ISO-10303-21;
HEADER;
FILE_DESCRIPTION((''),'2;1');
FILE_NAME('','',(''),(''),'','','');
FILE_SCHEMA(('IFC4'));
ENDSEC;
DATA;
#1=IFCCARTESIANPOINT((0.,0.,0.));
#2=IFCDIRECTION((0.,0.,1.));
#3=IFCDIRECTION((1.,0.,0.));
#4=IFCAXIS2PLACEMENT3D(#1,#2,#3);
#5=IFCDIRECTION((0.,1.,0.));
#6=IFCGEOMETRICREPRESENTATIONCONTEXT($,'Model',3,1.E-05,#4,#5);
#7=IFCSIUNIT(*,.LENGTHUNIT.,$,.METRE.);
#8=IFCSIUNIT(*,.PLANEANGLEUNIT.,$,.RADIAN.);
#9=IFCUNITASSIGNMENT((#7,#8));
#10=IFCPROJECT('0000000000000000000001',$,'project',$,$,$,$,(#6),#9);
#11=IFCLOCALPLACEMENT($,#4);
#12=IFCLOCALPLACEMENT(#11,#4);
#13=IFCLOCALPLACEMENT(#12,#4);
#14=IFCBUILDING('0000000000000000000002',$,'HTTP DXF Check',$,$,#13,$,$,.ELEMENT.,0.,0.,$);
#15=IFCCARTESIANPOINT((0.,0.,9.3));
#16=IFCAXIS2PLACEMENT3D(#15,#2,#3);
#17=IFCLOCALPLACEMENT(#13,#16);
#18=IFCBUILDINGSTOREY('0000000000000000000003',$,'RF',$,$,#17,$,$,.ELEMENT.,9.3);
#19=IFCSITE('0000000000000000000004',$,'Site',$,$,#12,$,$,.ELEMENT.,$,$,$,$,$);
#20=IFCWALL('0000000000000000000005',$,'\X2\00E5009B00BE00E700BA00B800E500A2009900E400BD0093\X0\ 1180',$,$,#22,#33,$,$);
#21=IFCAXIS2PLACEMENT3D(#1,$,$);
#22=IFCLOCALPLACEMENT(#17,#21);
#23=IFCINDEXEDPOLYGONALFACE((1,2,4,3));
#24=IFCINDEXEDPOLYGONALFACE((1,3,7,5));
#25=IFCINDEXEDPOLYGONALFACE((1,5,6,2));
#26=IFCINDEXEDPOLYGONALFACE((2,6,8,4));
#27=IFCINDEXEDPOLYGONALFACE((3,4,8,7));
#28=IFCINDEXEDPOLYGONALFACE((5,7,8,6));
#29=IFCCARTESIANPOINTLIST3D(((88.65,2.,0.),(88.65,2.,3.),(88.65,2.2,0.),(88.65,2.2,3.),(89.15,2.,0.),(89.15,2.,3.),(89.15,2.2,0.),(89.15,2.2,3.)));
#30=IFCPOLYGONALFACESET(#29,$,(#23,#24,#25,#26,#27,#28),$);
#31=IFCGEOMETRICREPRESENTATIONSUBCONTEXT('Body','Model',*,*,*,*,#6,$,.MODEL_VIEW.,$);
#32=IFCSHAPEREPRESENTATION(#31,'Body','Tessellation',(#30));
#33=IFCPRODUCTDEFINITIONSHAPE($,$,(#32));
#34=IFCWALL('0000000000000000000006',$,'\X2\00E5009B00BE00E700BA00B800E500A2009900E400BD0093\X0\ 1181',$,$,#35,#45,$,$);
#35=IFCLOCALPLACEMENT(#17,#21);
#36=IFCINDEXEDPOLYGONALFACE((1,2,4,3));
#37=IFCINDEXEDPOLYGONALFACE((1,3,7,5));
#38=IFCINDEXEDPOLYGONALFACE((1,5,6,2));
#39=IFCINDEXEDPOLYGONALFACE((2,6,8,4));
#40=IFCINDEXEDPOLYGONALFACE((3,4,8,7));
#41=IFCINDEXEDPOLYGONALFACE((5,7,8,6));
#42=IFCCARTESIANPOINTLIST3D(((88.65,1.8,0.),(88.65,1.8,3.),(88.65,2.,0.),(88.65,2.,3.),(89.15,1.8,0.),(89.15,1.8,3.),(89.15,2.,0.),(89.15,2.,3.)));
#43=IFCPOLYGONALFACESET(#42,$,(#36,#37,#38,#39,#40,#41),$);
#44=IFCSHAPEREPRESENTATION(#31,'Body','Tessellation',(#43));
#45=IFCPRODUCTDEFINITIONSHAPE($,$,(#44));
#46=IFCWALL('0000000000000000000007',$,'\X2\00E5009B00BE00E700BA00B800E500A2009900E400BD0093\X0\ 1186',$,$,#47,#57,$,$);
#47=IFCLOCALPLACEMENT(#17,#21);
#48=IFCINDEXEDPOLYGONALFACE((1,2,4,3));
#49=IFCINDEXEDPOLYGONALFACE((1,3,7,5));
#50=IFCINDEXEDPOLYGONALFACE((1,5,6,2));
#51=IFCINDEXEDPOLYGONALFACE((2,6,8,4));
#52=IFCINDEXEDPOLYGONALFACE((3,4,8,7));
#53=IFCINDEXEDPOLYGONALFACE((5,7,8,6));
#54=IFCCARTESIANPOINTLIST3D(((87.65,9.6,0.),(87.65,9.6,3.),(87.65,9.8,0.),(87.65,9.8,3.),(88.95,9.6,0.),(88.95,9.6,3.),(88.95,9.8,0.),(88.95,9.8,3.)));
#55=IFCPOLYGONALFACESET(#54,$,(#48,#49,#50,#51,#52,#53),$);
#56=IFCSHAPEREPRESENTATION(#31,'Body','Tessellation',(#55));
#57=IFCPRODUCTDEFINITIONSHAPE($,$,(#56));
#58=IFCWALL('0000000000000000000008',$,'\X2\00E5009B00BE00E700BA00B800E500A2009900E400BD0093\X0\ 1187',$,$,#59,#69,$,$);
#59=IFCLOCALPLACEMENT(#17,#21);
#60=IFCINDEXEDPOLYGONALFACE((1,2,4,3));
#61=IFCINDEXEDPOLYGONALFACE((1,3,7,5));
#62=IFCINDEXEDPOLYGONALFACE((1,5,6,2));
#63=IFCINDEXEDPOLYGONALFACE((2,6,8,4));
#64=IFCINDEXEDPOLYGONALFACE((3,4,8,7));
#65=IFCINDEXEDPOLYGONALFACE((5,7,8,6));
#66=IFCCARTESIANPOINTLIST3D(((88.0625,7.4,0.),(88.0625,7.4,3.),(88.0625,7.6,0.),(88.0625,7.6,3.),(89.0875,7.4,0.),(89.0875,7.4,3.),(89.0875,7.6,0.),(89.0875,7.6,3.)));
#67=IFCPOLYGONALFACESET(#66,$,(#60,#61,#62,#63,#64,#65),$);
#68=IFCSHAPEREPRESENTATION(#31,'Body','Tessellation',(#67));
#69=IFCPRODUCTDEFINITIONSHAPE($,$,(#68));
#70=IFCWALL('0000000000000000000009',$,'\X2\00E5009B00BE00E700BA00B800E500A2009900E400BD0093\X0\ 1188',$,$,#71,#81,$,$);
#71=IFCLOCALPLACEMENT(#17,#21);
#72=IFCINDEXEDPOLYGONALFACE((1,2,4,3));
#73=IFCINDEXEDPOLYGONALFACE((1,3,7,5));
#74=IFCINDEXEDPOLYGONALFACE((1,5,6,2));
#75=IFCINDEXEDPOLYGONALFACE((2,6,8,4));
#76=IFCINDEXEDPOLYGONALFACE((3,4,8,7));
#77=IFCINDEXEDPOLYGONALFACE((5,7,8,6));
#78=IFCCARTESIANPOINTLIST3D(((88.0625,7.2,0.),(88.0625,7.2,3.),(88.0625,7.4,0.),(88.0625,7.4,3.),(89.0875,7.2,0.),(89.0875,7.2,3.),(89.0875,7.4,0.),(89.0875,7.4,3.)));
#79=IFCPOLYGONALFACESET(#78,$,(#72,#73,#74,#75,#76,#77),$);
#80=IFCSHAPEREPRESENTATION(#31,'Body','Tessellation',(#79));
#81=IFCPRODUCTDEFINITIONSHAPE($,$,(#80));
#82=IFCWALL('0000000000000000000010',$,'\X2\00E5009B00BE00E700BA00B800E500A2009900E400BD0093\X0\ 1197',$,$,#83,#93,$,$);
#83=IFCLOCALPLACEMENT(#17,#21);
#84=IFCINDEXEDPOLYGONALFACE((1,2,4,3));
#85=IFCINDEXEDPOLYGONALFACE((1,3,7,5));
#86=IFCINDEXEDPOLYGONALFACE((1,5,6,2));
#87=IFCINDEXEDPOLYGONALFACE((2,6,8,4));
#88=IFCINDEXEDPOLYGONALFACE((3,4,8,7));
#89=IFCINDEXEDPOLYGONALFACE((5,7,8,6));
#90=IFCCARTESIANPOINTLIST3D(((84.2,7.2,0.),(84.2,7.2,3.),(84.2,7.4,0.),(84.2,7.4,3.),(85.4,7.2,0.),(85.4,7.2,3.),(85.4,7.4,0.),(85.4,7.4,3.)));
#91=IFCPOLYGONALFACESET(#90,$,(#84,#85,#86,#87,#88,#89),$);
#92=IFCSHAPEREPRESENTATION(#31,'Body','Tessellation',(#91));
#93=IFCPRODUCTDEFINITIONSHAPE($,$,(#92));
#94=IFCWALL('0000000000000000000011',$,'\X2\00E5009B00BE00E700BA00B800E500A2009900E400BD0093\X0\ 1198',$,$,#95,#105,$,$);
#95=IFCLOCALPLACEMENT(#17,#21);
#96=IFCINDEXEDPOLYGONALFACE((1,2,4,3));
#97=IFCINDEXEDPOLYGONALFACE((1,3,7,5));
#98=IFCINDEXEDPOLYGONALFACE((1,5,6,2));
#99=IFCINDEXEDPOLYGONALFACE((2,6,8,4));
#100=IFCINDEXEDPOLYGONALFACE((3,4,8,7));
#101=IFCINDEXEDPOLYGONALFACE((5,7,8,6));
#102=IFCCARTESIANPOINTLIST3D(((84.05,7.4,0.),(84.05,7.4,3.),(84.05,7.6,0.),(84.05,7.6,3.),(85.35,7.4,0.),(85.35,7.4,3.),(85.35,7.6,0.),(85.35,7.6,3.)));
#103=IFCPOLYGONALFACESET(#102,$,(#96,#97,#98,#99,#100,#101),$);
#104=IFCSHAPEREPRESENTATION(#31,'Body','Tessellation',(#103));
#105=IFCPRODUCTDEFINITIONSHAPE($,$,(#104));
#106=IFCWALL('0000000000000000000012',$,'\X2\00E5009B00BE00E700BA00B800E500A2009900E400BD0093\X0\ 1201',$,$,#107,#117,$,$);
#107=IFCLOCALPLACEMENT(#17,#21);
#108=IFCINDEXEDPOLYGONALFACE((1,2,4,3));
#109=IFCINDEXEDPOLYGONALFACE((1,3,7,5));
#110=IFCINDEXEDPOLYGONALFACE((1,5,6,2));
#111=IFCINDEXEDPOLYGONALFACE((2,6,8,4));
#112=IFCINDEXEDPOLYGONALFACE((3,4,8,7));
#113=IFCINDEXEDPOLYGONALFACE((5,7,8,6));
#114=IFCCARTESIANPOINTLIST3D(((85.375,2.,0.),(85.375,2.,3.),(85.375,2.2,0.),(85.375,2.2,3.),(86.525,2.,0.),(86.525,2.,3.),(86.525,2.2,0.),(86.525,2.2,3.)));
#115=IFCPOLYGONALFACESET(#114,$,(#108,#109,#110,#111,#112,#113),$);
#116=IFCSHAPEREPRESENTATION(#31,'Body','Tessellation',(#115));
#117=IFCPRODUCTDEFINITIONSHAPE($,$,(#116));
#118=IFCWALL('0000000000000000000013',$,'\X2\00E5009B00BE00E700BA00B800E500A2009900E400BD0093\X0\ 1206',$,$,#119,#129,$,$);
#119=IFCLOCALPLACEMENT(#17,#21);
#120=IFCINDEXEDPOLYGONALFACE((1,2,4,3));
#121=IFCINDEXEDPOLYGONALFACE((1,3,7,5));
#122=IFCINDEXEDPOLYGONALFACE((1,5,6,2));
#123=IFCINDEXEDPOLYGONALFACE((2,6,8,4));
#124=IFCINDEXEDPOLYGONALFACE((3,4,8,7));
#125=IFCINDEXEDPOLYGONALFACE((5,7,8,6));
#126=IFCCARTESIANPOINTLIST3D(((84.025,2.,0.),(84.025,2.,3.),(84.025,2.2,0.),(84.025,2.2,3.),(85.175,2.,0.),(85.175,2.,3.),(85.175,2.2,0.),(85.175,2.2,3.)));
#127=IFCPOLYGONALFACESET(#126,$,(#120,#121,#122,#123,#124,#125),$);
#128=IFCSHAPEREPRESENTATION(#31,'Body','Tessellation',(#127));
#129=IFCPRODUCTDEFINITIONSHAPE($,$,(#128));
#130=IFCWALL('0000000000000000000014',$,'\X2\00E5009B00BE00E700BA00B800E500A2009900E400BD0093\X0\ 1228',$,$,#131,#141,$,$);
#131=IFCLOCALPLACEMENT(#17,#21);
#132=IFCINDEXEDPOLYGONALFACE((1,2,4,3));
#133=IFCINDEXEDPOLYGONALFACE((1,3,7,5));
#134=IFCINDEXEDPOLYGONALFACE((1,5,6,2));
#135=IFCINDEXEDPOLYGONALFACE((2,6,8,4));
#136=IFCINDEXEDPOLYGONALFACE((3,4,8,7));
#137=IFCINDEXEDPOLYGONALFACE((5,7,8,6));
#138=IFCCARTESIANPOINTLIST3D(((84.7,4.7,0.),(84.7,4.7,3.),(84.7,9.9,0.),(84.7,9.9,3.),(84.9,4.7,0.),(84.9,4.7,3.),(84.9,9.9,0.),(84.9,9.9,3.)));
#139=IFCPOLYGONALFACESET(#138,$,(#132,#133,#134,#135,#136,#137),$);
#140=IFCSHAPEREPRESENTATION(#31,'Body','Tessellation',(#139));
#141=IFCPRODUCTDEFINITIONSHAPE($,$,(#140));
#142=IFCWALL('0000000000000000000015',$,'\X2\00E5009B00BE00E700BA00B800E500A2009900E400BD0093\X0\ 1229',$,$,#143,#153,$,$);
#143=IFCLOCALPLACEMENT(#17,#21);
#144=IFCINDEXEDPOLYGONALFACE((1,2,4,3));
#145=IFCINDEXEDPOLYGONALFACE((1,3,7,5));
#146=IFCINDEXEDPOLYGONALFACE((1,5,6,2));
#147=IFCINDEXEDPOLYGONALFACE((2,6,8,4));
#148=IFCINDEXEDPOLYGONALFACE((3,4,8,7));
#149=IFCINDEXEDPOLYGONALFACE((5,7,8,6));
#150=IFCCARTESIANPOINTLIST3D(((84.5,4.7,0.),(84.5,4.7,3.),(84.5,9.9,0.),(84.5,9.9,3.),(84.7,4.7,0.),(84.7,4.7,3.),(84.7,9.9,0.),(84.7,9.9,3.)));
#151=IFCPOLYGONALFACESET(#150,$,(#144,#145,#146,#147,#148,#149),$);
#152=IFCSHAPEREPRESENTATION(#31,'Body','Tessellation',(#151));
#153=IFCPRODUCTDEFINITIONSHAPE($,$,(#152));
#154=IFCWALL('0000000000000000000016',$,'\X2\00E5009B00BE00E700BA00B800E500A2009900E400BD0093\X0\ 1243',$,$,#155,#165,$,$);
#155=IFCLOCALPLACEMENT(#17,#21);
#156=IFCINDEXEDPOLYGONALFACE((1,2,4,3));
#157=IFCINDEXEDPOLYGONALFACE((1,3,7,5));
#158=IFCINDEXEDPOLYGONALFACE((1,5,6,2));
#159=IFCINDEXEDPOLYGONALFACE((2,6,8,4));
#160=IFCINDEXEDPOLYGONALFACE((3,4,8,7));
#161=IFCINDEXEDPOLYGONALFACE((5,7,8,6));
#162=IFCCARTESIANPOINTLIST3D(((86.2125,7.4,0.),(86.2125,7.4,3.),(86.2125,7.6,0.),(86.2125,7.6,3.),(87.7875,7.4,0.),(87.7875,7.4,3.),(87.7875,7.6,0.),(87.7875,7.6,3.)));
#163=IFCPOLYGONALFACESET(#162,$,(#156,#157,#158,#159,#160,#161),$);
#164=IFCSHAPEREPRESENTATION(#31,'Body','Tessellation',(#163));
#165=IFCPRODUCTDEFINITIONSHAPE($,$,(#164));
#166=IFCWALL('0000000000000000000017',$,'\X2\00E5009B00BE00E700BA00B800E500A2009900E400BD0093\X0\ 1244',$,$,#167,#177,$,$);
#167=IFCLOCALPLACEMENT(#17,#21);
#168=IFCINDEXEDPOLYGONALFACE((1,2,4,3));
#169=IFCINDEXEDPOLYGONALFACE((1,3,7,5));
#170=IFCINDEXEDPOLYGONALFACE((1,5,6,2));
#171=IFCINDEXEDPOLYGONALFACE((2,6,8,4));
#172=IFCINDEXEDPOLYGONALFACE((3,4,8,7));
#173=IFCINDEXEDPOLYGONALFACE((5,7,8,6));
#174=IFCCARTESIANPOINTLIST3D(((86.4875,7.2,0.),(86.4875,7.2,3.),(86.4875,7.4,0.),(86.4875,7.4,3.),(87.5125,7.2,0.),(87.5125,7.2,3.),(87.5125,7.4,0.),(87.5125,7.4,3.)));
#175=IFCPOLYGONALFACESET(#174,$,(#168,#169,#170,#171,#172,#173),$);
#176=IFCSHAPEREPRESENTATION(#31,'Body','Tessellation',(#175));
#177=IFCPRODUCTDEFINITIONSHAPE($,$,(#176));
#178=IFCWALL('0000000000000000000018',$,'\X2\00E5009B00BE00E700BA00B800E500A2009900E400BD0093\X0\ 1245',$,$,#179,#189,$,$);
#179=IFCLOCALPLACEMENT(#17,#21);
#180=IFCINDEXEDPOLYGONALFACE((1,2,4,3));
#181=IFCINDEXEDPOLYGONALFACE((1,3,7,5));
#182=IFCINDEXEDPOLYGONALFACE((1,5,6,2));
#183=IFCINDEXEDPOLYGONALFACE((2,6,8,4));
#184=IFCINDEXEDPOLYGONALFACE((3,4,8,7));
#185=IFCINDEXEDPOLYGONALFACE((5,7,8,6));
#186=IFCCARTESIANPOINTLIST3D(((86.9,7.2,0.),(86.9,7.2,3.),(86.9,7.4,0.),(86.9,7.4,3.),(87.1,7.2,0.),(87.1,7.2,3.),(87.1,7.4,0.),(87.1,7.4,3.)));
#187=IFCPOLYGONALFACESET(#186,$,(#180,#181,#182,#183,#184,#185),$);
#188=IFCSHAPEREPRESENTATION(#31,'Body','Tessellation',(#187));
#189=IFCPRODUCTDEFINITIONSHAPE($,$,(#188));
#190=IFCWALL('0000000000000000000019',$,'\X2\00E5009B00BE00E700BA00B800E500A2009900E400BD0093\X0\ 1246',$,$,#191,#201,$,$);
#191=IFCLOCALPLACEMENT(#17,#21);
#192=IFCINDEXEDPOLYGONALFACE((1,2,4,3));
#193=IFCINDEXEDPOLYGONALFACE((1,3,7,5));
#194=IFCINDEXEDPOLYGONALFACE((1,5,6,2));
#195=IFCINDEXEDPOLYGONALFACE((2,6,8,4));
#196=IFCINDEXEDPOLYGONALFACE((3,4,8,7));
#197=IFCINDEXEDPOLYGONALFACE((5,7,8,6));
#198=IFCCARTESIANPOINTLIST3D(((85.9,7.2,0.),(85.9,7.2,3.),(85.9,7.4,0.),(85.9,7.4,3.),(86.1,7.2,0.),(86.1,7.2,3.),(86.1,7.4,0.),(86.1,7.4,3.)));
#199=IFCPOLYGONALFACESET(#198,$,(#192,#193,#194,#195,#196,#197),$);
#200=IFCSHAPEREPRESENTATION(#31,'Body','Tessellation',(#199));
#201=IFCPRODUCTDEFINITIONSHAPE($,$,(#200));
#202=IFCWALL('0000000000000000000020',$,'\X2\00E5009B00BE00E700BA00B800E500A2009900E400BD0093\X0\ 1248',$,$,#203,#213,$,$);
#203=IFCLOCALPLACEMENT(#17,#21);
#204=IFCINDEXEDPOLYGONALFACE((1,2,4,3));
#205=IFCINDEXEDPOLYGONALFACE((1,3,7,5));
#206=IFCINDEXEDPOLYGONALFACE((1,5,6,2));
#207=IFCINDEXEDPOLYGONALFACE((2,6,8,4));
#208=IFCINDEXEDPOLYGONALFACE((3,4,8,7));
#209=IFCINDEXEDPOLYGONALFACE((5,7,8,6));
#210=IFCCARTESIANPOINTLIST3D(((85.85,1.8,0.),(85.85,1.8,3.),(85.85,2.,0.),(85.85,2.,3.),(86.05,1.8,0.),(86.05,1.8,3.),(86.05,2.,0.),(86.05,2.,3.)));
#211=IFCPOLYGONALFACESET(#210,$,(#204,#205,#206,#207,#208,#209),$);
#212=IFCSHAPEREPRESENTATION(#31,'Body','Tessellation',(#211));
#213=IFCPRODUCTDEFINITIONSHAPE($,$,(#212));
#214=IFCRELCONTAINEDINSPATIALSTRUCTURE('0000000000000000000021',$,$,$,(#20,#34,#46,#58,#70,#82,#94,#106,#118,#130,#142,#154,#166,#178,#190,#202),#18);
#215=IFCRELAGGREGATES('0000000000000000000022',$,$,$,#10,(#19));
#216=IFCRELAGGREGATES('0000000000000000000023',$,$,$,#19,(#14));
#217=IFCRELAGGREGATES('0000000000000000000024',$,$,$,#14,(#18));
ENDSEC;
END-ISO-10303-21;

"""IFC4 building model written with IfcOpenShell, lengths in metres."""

from ifc_helpers import new_model, si_unit, direction, frame, frame_2d, origin_with_axes, place, context, subcontext, project, spatial, rectangle, extrude, element, save


model = new_model("IFC4")

# Units and contexts
model_context = context("Model", 3, precision=1e-05, world=origin_with_axes(), true_north=direction((0.0, 1.0, 0.0)))
body_context = subcontext(model_context, "Body", "Model", "MODEL_VIEW")
ifc_project = project(units=[si_unit("LENGTHUNIT", "METRE"), si_unit("PLANEANGLEUNIT", "RADIAN")], contexts=[model_context])

# Site, building, storey
placement = place(None, origin_with_axes())
site_placement = place(placement, origin_with_axes())
site = spatial("IfcSite", under=ifc_project, at=site_placement, Name="Site", CompositionType="ELEMENT")
building_placement = place(site_placement, origin_with_axes())
building = spatial("IfcBuilding", under=site, at=building_placement, Name="HTTP DXF Check", CompositionType="ELEMENT", ElevationOfRefHeight=0.0, ElevationOfTerrain=0.0)
storey_placement = place(building_placement, frame((0.0, 0.0, 9.3), z_axis=(0.0, 0.0, 1.0), x_axis=(1.0, 0.0, 0.0)))
storey = spatial("IfcBuildingStorey", under=building, at=storey_placement, Name="RF", CompositionType="ELEMENT", Elevation=9.3)

# Walls
for number, where, z_axis, x_axis, name in (
    (1, (88.9, 2.1, 0.0), (0.0, 0.0, 1.0), (-1.0, 0.0, 0.0), "å\u009b¾çº¸å¢\u0099ä½\u0093 1180"),
    (2, (88.9, 1.9, 0.0), (0.0, 0.0, 1.0), (-1.0, 0.0, 0.0), "å\u009b¾çº¸å¢\u0099ä½\u0093 1181"),
):
    element("IfcWall", number, at=place(storey_placement, frame(where, z_axis=z_axis, x_axis=x_axis)), inside=storey, Name=name, context=body_context, shape_type="SweptSolid", body=[
        extrude(rectangle(XDim=0.5, YDim=0.2, at=frame_2d((0.0, 0.0), x_axis=(1.0, 0.0, 0.0))), frame((0.0, 0.0, 0.0), z_axis=(0.0, 0.0, 1.0)), (0.0, 0.0, 1.0), 3.0),
    ])
wall_1_placement = place(storey_placement, frame((88.3, 9.7, 0.0), z_axis=(0.0, 0.0, 1.0), x_axis=(1.0, 0.0, 0.0)))
element("IfcWall", 3, at=wall_1_placement, inside=storey, Name="å\u009b¾çº¸å¢\u0099ä½\u0093 1186", context=body_context, shape_type="SweptSolid", body=[
    extrude(rectangle(XDim=1.3, YDim=0.2, at=frame_2d((0.0, 0.0), x_axis=(1.0, 0.0, 0.0))), frame((0.0, 0.0, 0.0), z_axis=(0.0, 0.0, 1.0)), (0.0, 0.0, 1.0), 3.0),
])
for number, where, z_axis, x_axis, name in (
    (4, (88.575, 7.5, 0.0), (0.0, 0.0, 1.0), (1.0, 0.0, 0.0), "å\u009b¾çº¸å¢\u0099ä½\u0093 1187"),
    (5, (88.575, 7.3, 0.0), (0.0, 0.0, 1.0), (1.0, 0.0, 0.0), "å\u009b¾çº¸å¢\u0099ä½\u0093 1188"),
):
    element("IfcWall", number, at=place(storey_placement, frame(where, z_axis=z_axis, x_axis=x_axis)), inside=storey, Name=name, context=body_context, shape_type="SweptSolid", body=[
        extrude(rectangle(XDim=1.025, YDim=0.2, at=frame_2d((0.0, 0.0), x_axis=(1.0, 0.0, 0.0))), frame((0.0, 0.0, 0.0), z_axis=(0.0, 0.0, 1.0)), (0.0, 0.0, 1.0), 3.0),
    ])
wall_2_placement = place(storey_placement, frame((84.8, 7.3, 0.0), z_axis=(0.0, 0.0, 1.0), x_axis=(1.0, 0.0, 0.0)))
element("IfcWall", 6, at=wall_2_placement, inside=storey, Name="å\u009b¾çº¸å¢\u0099ä½\u0093 1197", context=body_context, shape_type="SweptSolid", body=[
    extrude(rectangle(XDim=1.2, YDim=0.2, at=frame_2d((0.0, 0.0), x_axis=(1.0, 0.0, 0.0))), frame((0.0, 0.0, 0.0), z_axis=(0.0, 0.0, 1.0)), (0.0, 0.0, 1.0), 3.0),
])
wall_3_placement = place(storey_placement, frame((84.7, 7.5, 0.0), z_axis=(0.0, 0.0, 1.0), x_axis=(1.0, 0.0, 0.0)))
element("IfcWall", 7, at=wall_3_placement, inside=storey, Name="å\u009b¾çº¸å¢\u0099ä½\u0093 1198", context=body_context, shape_type="SweptSolid", body=[
    extrude(rectangle(XDim=1.3, YDim=0.2, at=frame_2d((0.0, 0.0), x_axis=(1.0, 0.0, 0.0))), frame((0.0, 0.0, 0.0), z_axis=(0.0, 0.0, 1.0)), (0.0, 0.0, 1.0), 3.0),
])
for number, where, z_axis, x_axis, name in (
    (8, (85.95, 2.1, 0.0), (0.0, 0.0, 1.0), (-1.0, 0.0, 0.0), "å\u009b¾çº¸å¢\u0099ä½\u0093 1201"),
    (9, (84.6, 2.1, 0.0), (0.0, 0.0, 1.0), (-1.0, 0.0, 0.0), "å\u009b¾çº¸å¢\u0099ä½\u0093 1206"),
):
    element("IfcWall", number, at=place(storey_placement, frame(where, z_axis=z_axis, x_axis=x_axis)), inside=storey, Name=name, context=body_context, shape_type="SweptSolid", body=[
        extrude(rectangle(XDim=1.15, YDim=0.2, at=frame_2d((0.0, 0.0), x_axis=(1.0, 0.0, 0.0))), frame((0.0, 0.0, 0.0), z_axis=(0.0, 0.0, 1.0)), (0.0, 0.0, 1.0), 3.0),
    ])
for number, where, z_axis, x_axis, name in (
    (10, (84.8, 7.3, 0.0), (0.0, 0.0, 1.0), (0.0, -1.0, 0.0), "å\u009b¾çº¸å¢\u0099ä½\u0093 1228"),
    (11, (84.6, 7.3, 0.0), (0.0, 0.0, 1.0), (0.0, -1.0, 0.0), "å\u009b¾çº¸å¢\u0099ä½\u0093 1229"),
):
    element("IfcWall", number, at=place(storey_placement, frame(where, z_axis=z_axis, x_axis=x_axis)), inside=storey, Name=name, context=body_context, shape_type="SweptSolid", body=[
        extrude(rectangle(XDim=5.2, YDim=0.2, at=frame_2d((0.0, 0.0), x_axis=(1.0, 0.0, 0.0))), frame((0.0, 0.0, 0.0), z_axis=(0.0, 0.0, 1.0)), (0.0, 0.0, 1.0), 3.0),
    ])
wall_4_placement = place(storey_placement, frame((87.0, 7.5, 0.0), z_axis=(0.0, 0.0, 1.0), x_axis=(1.0, 0.0, 0.0)))
element("IfcWall", 12, at=wall_4_placement, inside=storey, Name="å\u009b¾çº¸å¢\u0099ä½\u0093 1243", context=body_context, shape_type="SweptSolid", body=[
    extrude(rectangle(XDim=1.575, YDim=0.2, at=frame_2d((0.0, 0.0), x_axis=(1.0, 0.0, 0.0))), frame((0.0, 0.0, 0.0), z_axis=(0.0, 0.0, 1.0)), (0.0, 0.0, 1.0), 3.0),
])
wall_5_placement = place(storey_placement, frame((87.0, 7.3, 0.0), z_axis=(0.0, 0.0, 1.0), x_axis=(1.0, 0.0, 0.0)))
element("IfcWall", 13, at=wall_5_placement, inside=storey, Name="å\u009b¾çº¸å¢\u0099ä½\u0093 1244", context=body_context, shape_type="SweptSolid", body=[
    extrude(rectangle(XDim=1.025, YDim=0.2, at=frame_2d((0.0, 0.0), x_axis=(1.0, 0.0, 0.0))), frame((0.0, 0.0, 0.0), z_axis=(0.0, 0.0, 1.0)), (0.0, 0.0, 1.0), 3.0),
])
for number, where, z_axis, x_axis, name in (
    (14, (87.0, 7.3, 0.0), (0.0, 0.0, 1.0), (0.0, 1.0, 0.0), "å\u009b¾çº¸å¢\u0099ä½\u0093 1245"),
    (15, (86.0, 7.3, 0.0), (0.0, 0.0, 1.0), (0.0, 1.0, 0.0), "å\u009b¾çº¸å¢\u0099ä½\u0093 1246"),
    (16, (85.95, 1.9, 0.0), (0.0, 0.0, 1.0), (0.0, 1.0, 0.0), "å\u009b¾çº¸å¢\u0099ä½\u0093 1248"),
):
    element("IfcWall", number, at=place(storey_placement, frame(where, z_axis=z_axis, x_axis=x_axis)), inside=storey, Name=name, context=body_context, shape_type="SweptSolid", body=[
        extrude(rectangle(XDim=0.2, YDim=0.2, at=frame_2d((0.0, 0.0), x_axis=(1.0, 0.0, 0.0))), frame((0.0, 0.0, 0.0), z_axis=(0.0, 0.0, 1.0)), (0.0, 0.0, 1.0), 3.0),
    ])

save(model, "model.ifc")
